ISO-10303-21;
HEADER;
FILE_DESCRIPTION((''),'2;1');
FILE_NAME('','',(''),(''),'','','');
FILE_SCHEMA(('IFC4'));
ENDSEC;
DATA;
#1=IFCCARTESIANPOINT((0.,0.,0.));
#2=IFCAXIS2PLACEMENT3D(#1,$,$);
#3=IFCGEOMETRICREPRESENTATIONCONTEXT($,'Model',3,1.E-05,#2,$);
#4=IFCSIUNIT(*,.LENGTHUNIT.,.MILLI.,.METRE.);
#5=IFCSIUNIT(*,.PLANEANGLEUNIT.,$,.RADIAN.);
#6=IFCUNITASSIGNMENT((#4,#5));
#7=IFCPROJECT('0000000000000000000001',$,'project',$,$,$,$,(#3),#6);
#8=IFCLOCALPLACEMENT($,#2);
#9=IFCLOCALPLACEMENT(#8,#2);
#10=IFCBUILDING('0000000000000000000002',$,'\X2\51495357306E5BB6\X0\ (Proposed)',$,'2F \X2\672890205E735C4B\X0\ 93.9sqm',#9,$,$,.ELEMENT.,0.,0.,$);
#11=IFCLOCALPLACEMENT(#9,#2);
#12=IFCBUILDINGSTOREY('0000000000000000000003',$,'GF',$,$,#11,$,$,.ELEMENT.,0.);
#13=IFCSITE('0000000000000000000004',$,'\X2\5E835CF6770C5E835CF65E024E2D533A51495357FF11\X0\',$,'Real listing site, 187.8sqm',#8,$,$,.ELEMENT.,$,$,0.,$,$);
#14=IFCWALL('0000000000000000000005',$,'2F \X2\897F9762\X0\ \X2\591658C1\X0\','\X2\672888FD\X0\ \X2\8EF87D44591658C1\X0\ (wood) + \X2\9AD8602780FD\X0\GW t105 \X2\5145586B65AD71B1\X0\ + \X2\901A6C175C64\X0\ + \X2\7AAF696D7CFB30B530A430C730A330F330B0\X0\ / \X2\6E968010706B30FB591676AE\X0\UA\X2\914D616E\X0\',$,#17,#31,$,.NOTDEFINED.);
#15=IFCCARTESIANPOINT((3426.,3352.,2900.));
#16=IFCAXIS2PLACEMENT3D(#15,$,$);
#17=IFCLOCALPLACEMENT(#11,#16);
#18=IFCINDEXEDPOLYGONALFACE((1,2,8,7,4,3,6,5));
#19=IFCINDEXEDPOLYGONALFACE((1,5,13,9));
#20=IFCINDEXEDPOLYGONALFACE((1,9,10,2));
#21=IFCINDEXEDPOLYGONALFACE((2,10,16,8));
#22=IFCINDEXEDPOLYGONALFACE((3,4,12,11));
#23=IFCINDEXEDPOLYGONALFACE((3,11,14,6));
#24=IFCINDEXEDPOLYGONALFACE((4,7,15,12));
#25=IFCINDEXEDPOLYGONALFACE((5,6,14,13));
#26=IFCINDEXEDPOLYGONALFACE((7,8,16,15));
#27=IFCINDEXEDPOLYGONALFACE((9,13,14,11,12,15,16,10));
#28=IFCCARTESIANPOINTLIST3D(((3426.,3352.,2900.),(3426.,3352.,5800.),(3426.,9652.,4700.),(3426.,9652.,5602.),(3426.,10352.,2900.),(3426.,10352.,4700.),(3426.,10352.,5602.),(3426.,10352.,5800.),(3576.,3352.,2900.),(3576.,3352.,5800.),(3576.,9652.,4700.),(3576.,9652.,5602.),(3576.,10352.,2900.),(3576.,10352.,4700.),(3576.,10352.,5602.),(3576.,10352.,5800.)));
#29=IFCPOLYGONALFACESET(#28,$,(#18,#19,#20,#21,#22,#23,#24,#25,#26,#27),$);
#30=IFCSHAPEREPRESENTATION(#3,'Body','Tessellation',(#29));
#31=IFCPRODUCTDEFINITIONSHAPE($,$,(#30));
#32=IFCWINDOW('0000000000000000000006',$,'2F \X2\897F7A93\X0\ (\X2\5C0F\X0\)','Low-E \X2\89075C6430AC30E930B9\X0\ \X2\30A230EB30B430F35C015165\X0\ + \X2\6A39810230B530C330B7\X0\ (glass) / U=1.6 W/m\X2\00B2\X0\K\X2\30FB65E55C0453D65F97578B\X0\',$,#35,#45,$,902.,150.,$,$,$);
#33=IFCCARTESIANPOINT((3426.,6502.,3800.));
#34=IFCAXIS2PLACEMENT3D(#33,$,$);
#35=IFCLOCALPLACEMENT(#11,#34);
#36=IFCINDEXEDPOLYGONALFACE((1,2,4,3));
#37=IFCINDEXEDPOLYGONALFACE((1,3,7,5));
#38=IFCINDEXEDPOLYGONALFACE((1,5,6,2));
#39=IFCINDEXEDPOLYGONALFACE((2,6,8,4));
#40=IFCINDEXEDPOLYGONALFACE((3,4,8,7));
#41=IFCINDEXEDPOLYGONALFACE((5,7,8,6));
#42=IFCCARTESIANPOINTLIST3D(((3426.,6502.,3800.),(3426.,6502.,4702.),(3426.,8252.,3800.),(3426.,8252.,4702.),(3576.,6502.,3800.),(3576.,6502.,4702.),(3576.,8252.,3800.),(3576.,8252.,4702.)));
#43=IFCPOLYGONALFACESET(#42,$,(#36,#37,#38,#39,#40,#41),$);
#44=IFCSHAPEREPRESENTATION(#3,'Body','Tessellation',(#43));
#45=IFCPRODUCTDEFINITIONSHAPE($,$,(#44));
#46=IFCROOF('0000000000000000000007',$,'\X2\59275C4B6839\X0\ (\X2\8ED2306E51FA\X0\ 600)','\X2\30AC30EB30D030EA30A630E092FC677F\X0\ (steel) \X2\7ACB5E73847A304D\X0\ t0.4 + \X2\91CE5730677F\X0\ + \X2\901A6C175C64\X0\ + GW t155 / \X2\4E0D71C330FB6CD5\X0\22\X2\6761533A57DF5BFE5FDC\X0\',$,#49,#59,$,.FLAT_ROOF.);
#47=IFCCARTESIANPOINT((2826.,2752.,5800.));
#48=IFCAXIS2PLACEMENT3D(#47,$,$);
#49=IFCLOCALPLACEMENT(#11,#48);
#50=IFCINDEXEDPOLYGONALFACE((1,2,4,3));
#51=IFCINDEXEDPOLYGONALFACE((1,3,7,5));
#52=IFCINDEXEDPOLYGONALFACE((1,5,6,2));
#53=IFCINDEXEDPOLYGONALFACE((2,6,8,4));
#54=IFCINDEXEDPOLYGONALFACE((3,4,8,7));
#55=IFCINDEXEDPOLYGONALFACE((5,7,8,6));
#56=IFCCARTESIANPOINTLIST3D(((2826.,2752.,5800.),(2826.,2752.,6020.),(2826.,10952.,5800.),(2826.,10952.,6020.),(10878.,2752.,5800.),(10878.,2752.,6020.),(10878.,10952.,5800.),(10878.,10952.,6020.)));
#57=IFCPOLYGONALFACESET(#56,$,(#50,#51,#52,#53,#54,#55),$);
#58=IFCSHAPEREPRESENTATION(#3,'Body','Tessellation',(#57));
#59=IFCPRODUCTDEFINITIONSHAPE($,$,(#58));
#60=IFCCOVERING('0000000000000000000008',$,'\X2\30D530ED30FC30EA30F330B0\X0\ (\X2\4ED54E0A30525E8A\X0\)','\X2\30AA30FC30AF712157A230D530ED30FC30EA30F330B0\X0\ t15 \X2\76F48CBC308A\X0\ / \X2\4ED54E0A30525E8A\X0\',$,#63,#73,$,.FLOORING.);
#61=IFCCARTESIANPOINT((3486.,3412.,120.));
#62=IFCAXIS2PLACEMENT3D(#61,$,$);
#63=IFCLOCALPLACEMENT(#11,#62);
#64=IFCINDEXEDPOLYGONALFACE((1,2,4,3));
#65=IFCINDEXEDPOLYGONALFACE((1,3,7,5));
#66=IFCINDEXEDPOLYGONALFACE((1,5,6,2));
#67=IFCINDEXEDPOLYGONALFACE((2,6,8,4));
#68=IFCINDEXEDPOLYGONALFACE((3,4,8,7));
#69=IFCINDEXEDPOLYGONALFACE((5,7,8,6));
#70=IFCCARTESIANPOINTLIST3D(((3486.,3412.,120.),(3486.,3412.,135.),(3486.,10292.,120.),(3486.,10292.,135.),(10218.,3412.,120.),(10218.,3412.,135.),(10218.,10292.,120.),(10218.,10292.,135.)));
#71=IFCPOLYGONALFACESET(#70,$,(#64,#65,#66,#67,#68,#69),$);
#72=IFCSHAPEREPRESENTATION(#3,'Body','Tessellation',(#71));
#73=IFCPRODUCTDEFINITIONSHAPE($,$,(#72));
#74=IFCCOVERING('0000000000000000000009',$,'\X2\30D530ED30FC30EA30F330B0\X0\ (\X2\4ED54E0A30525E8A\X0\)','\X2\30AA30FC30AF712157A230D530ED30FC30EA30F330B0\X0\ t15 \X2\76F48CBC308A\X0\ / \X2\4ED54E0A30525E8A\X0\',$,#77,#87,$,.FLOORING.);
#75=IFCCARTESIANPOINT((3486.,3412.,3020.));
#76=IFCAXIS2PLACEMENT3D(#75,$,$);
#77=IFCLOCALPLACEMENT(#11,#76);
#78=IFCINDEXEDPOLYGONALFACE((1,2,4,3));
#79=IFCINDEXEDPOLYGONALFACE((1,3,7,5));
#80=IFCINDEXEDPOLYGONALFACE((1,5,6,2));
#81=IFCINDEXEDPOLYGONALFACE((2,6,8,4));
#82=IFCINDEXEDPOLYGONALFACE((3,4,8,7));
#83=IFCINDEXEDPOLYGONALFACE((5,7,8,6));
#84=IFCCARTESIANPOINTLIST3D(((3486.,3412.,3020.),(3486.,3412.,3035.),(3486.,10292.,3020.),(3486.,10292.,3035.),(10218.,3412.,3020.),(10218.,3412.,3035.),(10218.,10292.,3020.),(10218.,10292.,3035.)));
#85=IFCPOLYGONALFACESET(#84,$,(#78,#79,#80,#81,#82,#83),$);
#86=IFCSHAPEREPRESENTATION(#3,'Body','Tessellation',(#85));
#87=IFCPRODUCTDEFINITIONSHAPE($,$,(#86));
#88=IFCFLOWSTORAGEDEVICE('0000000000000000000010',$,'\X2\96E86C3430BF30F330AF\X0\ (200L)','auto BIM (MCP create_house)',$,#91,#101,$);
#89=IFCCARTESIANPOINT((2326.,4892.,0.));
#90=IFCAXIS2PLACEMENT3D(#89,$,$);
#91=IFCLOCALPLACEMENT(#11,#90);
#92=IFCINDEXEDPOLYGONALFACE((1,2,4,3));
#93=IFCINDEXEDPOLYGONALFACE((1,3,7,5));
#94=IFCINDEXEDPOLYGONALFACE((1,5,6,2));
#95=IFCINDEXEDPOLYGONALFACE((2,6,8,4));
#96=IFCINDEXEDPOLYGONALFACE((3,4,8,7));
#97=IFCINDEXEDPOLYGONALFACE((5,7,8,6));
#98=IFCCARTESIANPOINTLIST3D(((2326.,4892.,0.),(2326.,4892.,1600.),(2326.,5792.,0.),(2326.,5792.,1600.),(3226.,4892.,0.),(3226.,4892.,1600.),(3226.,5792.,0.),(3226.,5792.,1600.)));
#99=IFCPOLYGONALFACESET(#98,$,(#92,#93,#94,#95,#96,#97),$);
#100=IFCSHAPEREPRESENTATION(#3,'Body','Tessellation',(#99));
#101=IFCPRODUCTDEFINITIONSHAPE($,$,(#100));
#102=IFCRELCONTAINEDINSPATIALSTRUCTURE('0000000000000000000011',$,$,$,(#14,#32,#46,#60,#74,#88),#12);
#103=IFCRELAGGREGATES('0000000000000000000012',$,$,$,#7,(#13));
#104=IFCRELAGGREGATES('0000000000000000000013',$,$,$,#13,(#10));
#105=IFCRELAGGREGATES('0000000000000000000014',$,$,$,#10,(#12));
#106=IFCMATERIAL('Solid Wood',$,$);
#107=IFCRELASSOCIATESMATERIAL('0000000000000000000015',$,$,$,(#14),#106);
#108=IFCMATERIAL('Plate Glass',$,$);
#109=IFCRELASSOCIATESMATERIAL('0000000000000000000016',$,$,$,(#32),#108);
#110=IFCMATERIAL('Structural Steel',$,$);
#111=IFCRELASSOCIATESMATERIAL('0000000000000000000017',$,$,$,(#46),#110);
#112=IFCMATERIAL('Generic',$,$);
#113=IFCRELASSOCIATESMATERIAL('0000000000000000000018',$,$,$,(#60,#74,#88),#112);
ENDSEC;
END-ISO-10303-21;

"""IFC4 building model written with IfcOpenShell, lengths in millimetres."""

from ifc_helpers import new_model, si_unit, frame, frame_2d, origin, place, context, project, spatial, rectangle, extrude, material, element, fill, save


model = new_model("IFC4")

# Units and contexts
model_context = context("Model", 3, precision=1e-05, world=origin())
ifc_project = project(units=[si_unit("LENGTHUNIT", "METRE", prefix="MILLI"), si_unit("PLANEANGLEUNIT", "RADIAN")], contexts=[model_context])

# Site, building, storey
site_placement = place(None, origin())
site = spatial("IfcSite", under=ifc_project, at=site_placement, Name="広島県広島市中区光南１", ObjectType="Real listing site, 187.8sqm", CompositionType="ELEMENT", RefElevation=0.0)
building_placement = place(site_placement, origin())
building = spatial("IfcBuilding", under=site, at=building_placement, Name="光南の家 (Proposed)", ObjectType="2F 木造平屋 93.9sqm", CompositionType="ELEMENT", ElevationOfRefHeight=0.0, ElevationOfTerrain=0.0)
storey_placement = place(building_placement, origin())
storey = spatial("IfcBuildingStorey", under=building, at=storey_placement, Name="GF", CompositionType="ELEMENT", Elevation=0.0)

# Shared definitions
ifc_material_1 = material(Name="Solid Wood")

# Shared definitions
ifc_material_2 = material(Name="Plate Glass")

# Wall, opening, window
wall_1_placement = place(storey_placement, frame((3426.0, 3352.0, 2900.0)))
wall_1 = element("IfcWall", 1, at=wall_1_placement, inside=storey, material=ifc_material_1, Name="2F 西面 外壁", Description="木製 軸組外壁 (wood) + 高性能GW t105 充填断熱 + 通気層 + 窯業系サイディング / 準耐火・外皮UA配慮", PredefinedType="NOTDEFINED", context=model_context, shape_type="SweptSolid", body=[
    extrude(rectangle(XDim=150.0, YDim=7000.0, at=frame_2d((75.0, 3500.0))), frame((3426.0, 3352.0, 2900.0)), (0.0, 0.0, 1.0), 2900.0),
])
opening_1_placement = place(storey_placement, frame((3426.0, 6502.0, 3800.0)))
opening_1 = element("IfcOpeningElement", 2, at=opening_1_placement, cuts=wall_1, PredefinedType="NOTDEFINED", context=model_context, shape_type="SweptSolid", body=[
    extrude(rectangle(XDim=150.0, YDim=1750.0, at=frame_2d((75.0, 875.0))), frame((3426.0, 6502.0, 3800.0)), (0.0, 0.0, 1.0), 902.0),
])
window_1_placement = place(storey_placement, frame((3426.0, 6502.0, 3800.0)))
window_1 = element("IfcWindow", 3, at=window_1_placement, inside=storey, material=ifc_material_2, Name="2F 西窓 (小)", Description="Low-E 複層ガラス アルゴン封入 + 樹脂サッシ (glass) / U=1.6 W/m²K・日射取得型", OverallHeight=902.0, OverallWidth=150.0, context=model_context, shape_type="SweptSolid", body=[
    extrude(rectangle(XDim=150.0, YDim=1750.0, at=frame_2d((75.0, 875.0))), frame((3426.0, 6502.0, 3800.0)), (0.0, 0.0, 1.0), 902.0),
])
fill(opening_1, window_1)

# Roof
ifc_material_3 = material(Name="Structural Steel")
roof_placement = place(storey_placement, frame((2826.0, 2752.0, 5800.0)))
element("IfcRoof", 4, at=roof_placement, inside=storey, material=ifc_material_3, Name="大屋根 (軒の出 600)", Description="ガルバリウム鋼板 (steel) 立平葺き t0.4 + 野地板 + 通気層 + GW t155 / 不燃・法22条区域対応", PredefinedType="FLAT_ROOF", context=model_context, shape_type="SweptSolid", body=[
    extrude(rectangle(XDim=8052.0, YDim=8200.0, at=frame_2d((4026.0, 4100.0))), frame((2826.0, 2752.0, 5800.0)), (0.0, 0.0, 1.0), 220.0),
])

# Coverings
ifc_material_4 = material(Name="Generic")
covering_1_placement = place(storey_placement, frame((3486.0, 3412.0, 120.0)))
element("IfcCovering", 5, at=covering_1_placement, inside=storey, material=ifc_material_4, Name="フローリング (仕上げ床)", Description="オーク無垢フローリング t15 直貼り / 仕上げ床", PredefinedType="FLOORING", context=model_context, shape_type="SweptSolid", body=[
    extrude(rectangle(XDim=6732.0, YDim=6880.0, at=frame_2d((3366.0, 3440.0))), frame((3486.0, 3412.0, 120.0)), (0.0, 0.0, 1.0), 15.0),
])
covering_2_placement = place(storey_placement, frame((3486.0, 3412.0, 3020.0)))
element("IfcCovering", 6, at=covering_2_placement, inside=storey, material=ifc_material_4, Name="フローリング (仕上げ床)", Description="オーク無垢フローリング t15 直貼り / 仕上げ床", PredefinedType="FLOORING", context=model_context, shape_type="SweptSolid", body=[
    extrude(rectangle(XDim=6732.0, YDim=6880.0, at=frame_2d((3366.0, 3440.0))), frame((3486.0, 3412.0, 3020.0)), (0.0, 0.0, 1.0), 15.0),
])

# Flow storage device
flow_storage_device_placement = place(storey_placement, frame((2326.0, 4892.0, 0.0)))
element("IfcFlowStorageDevice", 7, at=flow_storage_device_placement, inside=storey, material=ifc_material_4, Name="雨水タンク (200L)", Description="auto BIM (MCP create_house)", context=model_context, shape_type="SweptSolid", body=[
    extrude(rectangle(XDim=900.0, YDim=900.0, at=frame_2d((450.0, 450.0))), frame((2326.0, 4892.0, 0.0)), (0.0, 0.0, 1.0), 1600.0),
])

save(model, "model.ifc")
